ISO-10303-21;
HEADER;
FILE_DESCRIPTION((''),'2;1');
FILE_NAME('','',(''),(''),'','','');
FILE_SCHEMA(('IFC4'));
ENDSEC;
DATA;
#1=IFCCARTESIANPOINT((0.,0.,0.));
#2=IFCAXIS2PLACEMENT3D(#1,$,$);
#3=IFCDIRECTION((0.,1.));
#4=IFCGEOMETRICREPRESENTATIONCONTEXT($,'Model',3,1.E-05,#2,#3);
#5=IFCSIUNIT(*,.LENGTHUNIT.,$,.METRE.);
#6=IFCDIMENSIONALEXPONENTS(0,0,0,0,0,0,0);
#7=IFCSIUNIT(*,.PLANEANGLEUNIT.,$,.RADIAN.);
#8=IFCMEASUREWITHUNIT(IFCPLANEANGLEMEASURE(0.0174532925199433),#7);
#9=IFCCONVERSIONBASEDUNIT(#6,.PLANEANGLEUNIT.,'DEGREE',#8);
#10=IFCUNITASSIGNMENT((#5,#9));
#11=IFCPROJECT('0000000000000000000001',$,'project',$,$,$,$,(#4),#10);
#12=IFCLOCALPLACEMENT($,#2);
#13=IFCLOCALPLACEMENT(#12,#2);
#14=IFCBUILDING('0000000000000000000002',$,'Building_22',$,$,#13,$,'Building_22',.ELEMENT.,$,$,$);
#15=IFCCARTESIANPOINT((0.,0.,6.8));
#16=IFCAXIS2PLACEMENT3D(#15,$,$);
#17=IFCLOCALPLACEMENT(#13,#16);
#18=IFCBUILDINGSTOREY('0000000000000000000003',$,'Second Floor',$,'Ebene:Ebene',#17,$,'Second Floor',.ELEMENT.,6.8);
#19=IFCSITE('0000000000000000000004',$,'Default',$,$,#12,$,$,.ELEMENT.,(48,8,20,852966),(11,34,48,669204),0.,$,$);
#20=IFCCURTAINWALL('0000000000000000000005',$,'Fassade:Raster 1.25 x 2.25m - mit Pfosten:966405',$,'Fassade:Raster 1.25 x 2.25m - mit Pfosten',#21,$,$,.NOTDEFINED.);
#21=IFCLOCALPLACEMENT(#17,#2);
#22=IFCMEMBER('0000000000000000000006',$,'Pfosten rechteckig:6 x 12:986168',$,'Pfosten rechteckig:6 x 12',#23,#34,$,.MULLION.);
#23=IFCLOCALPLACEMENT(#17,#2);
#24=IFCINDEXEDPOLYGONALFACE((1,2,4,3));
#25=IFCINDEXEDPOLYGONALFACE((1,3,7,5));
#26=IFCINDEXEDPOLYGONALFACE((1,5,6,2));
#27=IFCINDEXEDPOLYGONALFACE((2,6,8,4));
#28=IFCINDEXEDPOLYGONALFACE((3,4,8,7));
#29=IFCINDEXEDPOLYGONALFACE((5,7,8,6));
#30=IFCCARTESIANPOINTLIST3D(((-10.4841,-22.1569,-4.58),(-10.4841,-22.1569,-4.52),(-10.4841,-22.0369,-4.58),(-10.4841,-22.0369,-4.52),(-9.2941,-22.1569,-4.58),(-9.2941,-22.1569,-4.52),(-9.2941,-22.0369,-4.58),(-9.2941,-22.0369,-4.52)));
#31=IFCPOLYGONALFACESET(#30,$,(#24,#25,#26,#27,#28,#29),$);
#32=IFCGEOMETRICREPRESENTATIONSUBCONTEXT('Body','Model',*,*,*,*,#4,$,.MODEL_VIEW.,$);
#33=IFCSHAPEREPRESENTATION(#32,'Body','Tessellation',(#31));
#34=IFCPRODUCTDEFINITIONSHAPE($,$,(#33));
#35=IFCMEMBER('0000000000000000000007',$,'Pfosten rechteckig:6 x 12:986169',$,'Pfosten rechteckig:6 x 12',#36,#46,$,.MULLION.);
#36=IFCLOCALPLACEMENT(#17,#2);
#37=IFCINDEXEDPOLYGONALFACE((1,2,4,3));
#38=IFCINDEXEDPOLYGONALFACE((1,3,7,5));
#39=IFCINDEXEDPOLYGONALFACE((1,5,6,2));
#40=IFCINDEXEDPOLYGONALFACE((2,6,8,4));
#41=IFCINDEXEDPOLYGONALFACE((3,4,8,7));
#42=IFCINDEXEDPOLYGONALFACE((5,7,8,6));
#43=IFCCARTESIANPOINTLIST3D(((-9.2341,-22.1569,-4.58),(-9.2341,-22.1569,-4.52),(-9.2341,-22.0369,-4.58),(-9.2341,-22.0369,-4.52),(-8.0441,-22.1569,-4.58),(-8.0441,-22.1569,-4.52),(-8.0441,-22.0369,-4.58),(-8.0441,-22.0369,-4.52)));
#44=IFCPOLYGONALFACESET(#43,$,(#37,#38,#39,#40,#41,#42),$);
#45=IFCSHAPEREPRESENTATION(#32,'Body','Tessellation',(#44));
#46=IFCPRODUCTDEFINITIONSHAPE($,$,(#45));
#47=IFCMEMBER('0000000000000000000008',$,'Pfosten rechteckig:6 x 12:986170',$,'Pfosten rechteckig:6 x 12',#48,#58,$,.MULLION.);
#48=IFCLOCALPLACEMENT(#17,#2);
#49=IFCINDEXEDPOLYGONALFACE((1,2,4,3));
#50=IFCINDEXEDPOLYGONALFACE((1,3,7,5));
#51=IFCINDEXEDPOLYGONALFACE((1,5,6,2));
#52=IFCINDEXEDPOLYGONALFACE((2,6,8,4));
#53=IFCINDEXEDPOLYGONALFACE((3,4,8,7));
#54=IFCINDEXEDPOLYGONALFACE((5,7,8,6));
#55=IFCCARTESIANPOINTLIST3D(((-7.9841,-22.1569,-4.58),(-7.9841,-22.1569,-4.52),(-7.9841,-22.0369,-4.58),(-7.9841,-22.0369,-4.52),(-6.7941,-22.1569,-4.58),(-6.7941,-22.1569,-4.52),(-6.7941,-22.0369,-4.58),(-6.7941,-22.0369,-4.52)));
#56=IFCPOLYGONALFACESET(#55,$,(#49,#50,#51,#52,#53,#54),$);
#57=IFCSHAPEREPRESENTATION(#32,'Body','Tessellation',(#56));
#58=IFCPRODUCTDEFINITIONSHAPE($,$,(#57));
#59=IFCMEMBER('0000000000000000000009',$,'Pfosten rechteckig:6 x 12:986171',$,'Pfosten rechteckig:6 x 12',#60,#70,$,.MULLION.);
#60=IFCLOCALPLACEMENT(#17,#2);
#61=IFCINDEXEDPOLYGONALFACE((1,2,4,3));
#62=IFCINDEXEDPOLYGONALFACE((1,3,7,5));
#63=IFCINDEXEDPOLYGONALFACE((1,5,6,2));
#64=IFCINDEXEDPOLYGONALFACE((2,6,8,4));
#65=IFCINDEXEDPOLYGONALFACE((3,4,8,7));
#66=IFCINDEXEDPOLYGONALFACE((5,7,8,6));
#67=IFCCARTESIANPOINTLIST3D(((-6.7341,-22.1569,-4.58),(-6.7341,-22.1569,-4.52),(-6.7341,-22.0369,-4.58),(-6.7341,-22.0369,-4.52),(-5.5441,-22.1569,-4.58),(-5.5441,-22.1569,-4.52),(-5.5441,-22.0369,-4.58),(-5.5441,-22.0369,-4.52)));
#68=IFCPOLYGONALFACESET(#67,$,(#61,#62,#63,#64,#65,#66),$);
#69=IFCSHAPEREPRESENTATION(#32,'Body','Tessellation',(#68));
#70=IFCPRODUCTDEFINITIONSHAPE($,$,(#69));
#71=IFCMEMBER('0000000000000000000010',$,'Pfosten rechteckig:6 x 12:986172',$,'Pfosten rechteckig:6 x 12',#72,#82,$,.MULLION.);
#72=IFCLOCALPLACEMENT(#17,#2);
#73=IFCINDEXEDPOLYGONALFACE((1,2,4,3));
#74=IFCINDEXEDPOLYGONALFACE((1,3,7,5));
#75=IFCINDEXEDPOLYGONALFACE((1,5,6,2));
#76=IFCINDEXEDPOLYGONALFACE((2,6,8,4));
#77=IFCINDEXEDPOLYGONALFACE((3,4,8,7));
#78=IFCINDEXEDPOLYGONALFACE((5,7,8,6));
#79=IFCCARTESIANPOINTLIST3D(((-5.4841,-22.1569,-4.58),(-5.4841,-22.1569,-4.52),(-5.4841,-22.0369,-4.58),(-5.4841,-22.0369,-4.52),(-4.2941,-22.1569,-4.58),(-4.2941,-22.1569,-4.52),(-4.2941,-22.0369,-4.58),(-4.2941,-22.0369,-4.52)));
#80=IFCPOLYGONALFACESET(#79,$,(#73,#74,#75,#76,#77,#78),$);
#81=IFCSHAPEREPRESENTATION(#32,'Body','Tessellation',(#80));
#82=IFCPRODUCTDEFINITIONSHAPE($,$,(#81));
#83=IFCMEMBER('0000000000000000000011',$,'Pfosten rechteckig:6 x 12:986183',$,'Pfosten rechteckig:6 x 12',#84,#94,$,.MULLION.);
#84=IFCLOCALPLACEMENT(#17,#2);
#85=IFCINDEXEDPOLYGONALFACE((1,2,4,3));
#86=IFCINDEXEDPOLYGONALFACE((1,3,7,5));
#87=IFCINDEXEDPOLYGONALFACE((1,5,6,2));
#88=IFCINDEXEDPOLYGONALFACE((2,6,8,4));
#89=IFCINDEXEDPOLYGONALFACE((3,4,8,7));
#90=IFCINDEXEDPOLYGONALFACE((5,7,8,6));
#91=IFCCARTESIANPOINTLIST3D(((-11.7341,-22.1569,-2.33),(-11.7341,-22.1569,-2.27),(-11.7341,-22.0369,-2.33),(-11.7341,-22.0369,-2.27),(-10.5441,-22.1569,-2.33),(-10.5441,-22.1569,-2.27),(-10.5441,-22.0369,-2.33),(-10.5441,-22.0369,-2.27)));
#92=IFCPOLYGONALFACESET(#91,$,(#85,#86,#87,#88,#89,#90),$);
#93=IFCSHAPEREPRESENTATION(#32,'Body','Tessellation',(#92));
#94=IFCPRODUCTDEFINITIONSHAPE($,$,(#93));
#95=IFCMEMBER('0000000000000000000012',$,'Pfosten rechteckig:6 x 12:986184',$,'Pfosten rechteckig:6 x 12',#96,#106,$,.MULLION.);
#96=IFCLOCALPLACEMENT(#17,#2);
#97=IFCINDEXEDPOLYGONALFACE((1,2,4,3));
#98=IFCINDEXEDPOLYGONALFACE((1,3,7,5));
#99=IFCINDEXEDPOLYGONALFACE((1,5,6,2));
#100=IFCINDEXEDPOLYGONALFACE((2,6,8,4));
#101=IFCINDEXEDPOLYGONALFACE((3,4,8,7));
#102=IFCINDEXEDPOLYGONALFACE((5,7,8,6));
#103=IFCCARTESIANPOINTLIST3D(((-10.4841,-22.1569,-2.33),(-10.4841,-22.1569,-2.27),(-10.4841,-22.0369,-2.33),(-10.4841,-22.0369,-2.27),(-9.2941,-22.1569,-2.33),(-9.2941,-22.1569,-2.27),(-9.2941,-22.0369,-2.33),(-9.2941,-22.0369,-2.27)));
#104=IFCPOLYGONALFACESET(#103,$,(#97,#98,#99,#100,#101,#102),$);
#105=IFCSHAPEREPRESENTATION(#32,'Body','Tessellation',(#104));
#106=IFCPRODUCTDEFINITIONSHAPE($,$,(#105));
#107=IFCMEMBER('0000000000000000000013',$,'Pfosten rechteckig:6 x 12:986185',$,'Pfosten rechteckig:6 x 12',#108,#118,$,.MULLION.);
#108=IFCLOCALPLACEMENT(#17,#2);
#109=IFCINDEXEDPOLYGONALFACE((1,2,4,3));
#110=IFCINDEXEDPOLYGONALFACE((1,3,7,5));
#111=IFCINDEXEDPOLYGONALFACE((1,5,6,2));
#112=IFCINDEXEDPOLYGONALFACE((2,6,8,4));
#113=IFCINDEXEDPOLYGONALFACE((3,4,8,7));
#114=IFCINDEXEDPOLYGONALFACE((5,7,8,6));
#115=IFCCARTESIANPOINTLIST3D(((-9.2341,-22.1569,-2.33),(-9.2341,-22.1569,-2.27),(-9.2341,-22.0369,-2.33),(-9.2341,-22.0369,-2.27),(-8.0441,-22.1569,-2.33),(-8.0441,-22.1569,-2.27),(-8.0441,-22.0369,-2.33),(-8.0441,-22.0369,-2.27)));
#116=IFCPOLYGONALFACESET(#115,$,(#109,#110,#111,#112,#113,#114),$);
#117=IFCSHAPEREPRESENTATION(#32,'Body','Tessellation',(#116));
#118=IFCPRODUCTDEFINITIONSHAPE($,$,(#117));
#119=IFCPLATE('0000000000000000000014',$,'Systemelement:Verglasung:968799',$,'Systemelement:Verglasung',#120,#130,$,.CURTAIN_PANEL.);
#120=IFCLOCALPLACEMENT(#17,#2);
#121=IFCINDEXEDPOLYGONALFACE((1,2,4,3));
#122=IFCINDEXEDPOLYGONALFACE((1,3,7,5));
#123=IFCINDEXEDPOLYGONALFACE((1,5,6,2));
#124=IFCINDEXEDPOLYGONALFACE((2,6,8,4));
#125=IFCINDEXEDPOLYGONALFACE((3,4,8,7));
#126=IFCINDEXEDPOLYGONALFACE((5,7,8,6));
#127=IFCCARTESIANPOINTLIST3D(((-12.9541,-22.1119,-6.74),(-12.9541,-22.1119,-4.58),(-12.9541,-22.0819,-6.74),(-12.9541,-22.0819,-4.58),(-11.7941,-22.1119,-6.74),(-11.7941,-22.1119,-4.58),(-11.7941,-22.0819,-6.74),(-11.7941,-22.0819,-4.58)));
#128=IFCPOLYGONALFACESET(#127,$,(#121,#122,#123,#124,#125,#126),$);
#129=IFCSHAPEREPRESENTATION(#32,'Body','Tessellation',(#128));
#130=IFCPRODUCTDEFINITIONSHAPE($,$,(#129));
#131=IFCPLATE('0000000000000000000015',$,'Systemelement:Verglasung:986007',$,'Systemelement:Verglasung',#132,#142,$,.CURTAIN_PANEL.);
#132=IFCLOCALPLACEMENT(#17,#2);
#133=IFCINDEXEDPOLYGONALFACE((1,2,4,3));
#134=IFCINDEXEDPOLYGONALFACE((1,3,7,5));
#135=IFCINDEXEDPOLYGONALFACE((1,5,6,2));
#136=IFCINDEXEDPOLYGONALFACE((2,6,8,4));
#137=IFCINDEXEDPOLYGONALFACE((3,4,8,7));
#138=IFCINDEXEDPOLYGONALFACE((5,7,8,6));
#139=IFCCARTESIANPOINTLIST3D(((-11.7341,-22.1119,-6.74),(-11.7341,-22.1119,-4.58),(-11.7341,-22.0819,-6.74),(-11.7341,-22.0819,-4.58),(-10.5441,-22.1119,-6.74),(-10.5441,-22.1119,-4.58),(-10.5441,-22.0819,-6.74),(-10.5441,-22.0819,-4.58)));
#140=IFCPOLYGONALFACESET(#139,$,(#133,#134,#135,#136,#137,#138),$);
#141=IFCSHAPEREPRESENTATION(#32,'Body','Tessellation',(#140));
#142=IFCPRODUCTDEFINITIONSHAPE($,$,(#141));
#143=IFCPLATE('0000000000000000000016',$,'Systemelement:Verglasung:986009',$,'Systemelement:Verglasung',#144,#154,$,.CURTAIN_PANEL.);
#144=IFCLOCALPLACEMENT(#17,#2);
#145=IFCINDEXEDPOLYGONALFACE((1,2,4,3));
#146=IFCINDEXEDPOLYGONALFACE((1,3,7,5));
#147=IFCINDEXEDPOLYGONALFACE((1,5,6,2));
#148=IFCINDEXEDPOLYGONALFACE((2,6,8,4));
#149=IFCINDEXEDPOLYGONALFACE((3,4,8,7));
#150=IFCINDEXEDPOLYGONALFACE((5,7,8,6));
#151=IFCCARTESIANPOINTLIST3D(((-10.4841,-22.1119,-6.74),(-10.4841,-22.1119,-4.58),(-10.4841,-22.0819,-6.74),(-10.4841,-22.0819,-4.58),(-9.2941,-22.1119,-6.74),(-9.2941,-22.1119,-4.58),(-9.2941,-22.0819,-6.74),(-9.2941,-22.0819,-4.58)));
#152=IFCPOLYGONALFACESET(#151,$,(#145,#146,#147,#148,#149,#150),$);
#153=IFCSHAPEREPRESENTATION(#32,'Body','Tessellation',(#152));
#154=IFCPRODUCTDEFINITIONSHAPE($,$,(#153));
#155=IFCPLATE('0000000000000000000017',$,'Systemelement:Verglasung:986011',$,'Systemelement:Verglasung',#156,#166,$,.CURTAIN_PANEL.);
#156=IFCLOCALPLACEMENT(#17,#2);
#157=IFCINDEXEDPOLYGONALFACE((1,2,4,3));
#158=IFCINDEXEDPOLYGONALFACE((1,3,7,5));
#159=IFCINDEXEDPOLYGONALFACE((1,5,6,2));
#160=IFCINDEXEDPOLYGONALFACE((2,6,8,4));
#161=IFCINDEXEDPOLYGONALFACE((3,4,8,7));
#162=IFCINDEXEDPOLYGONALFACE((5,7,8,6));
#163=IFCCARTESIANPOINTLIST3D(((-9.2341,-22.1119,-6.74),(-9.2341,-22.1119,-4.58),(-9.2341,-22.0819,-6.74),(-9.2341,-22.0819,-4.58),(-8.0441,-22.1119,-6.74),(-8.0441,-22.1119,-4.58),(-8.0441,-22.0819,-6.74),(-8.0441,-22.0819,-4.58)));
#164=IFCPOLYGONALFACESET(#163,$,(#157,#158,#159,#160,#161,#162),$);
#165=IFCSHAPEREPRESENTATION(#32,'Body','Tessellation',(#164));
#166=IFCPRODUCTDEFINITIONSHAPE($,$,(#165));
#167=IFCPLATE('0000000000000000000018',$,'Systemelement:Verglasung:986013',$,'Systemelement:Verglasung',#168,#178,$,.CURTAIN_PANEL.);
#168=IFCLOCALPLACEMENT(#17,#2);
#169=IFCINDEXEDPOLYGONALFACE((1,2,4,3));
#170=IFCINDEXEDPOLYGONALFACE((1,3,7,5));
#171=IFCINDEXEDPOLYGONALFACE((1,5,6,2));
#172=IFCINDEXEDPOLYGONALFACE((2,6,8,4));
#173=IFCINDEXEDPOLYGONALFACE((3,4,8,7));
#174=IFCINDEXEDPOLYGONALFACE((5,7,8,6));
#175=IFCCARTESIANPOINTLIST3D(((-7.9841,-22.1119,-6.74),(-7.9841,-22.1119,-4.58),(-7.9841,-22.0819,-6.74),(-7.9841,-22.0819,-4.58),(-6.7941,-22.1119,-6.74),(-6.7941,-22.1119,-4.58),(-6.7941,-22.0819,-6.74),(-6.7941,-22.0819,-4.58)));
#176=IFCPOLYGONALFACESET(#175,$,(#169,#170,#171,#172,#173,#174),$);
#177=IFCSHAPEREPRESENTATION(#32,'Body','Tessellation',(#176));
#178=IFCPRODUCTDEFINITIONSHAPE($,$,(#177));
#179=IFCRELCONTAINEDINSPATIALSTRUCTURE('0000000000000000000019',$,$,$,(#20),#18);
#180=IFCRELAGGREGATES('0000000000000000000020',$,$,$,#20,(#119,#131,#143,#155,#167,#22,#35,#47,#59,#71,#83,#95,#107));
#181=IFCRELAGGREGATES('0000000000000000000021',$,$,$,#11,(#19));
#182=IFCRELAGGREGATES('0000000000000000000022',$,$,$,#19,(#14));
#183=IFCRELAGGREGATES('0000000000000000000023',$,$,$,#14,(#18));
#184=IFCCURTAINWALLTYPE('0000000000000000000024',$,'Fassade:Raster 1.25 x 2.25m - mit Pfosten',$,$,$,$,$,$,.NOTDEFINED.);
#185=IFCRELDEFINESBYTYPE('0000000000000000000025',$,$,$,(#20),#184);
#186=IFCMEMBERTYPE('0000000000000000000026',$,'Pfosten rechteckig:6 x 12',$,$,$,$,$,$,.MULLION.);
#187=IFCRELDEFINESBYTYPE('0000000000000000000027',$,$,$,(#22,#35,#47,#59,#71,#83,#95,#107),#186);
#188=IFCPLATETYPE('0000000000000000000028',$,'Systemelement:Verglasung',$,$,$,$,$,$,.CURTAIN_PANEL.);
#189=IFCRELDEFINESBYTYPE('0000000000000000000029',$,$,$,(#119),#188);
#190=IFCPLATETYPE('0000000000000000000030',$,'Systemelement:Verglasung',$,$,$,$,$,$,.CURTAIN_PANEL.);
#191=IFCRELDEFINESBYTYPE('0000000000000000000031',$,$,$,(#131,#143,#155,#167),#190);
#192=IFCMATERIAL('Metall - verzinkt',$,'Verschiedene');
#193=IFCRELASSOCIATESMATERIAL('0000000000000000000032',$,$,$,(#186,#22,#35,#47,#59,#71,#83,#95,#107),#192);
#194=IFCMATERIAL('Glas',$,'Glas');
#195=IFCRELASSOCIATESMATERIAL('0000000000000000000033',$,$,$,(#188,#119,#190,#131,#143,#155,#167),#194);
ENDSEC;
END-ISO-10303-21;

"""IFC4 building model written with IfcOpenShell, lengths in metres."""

from ifc_helpers import new_model, entity, si_unit, converted_unit, direction, frame, origin, place, context, subcontext, project, spatial, indexed_curve, outline, extrude, source, transform, mapped, material, type_object, type_shapes, element, aggregate, save


model = new_model("IFC4")

# Units and contexts
model_context = context("Model", 3, precision=1e-05, world=origin(), true_north=direction((0.0, 1.0)))
body_context = subcontext(model_context, "Body", "Model", "MODEL_VIEW")
ifc_project = project(units=[si_unit("LENGTHUNIT", "METRE"), converted_unit("PLANEANGLEUNIT", "DEGREE", entity("IfcPlaneAngleMeasure", 0.0174532925199433), si_unit("PLANEANGLEUNIT", "RADIAN"), dimensions=[0, 0, 0, 0, 0, 0, 0])], contexts=[model_context])

# Site, building, storey
site_placement = place(None, origin())
site = spatial("IfcSite", under=ifc_project, at=site_placement, Name="Default", CompositionType="ELEMENT", RefLatitude=(48, 8, 20, 852966), RefLongitude=(11, 34, 48, 669204), RefElevation=0.0)
building_placement = place(site_placement, origin())
building = spatial("IfcBuilding", under=site, at=building_placement, Name="Building_22", LongName="Building_22", CompositionType="ELEMENT")
storey_placement = place(building_placement, frame((0.0, 0.0, 6.8)))
storey = spatial("IfcBuildingStorey", under=building, at=storey_placement, Name="Second Floor", ObjectType="Ebene:Ebene", LongName="Second Floor", CompositionType="ELEMENT", Elevation=6.8)

# Curtain wall, members, plates
curtain_wall_type = type_object("IfcCurtainWallType", Name="Fassade:Raster 1.25 x 2.25m - mit Pfosten", PredefinedType="NOTDEFINED")
curtain_wall_placement = place(storey_placement, frame((0.0, 0.0, -6.8)))
curtain_wall = element("IfcCurtainWall", 1, at=curtain_wall_placement, inside=storey, type_object=curtain_wall_type, Name="Fassade:Raster 1.25 x 2.25m - mit Pfosten:966405", ObjectType="Fassade:Raster 1.25 x 2.25m - mit Pfosten", PredefinedType="NOTDEFINED")
ifc_material_1 = material(Name="Metall - verzinkt", Category="Verschiedene")
member_type_1 = type_object("IfcMemberType", Name="Pfosten rechteckig:6 x 12", PredefinedType="MULLION", material=ifc_material_1)
shared_shape_1 = source(origin(), body_context, "Body", "SweptSolid", [
    extrude(outline(indexed_curve([(-0.03, -0.06), (0.03, -0.06), (0.03, 0.06), (-0.03, 0.06), (-0.03, -0.06)], self_intersect=False)), frame((0.0, 0.0, -1.19), z_axis=(0.0, 0.0, 1.0), x_axis=(-1.0, 0.0, 0.0)), (0.0, 0.0, 1.0), 1.19),
])
type_shapes(member_type_1, [shared_shape_1])
member_1_placement = place(curtain_wall_placement, frame((-9.2941, -22.0969, 2.25), z_axis=(1.0, 0.0, 0.0), x_axis=(0.0, 0.0, 1.0)))
member_1 = element("IfcMember", 2, at=member_1_placement, type_object=member_type_1, material=ifc_material_1, Name="Pfosten rechteckig:6 x 12:986168", ObjectType="Pfosten rechteckig:6 x 12", PredefinedType="MULLION", context=body_context, shape_type="MappedRepresentation", body=[
    mapped(shared_shape_1, transform((0.0, 0.0, 0.0), scale=1.0)),
])
member_2_placement = place(curtain_wall_placement, frame((-8.0441, -22.0969, 2.25), z_axis=(1.0, 0.0, 0.0), x_axis=(0.0, 0.0, 1.0)))
member_2 = element("IfcMember", 3, at=member_2_placement, type_object=member_type_1, material=ifc_material_1, Name="Pfosten rechteckig:6 x 12:986169", ObjectType="Pfosten rechteckig:6 x 12", PredefinedType="MULLION", context=body_context, shape_type="MappedRepresentation", body=[
    mapped(shared_shape_1, transform((0.0, 0.0, 0.0), scale=1.0)),
])
member_3_placement = place(curtain_wall_placement, frame((-6.7941, -22.0969, 2.25), z_axis=(1.0, 0.0, 0.0), x_axis=(0.0, 0.0, 1.0)))
member_3 = element("IfcMember", 4, at=member_3_placement, type_object=member_type_1, material=ifc_material_1, Name="Pfosten rechteckig:6 x 12:986170", ObjectType="Pfosten rechteckig:6 x 12", PredefinedType="MULLION", context=body_context, shape_type="MappedRepresentation", body=[
    mapped(shared_shape_1, transform((0.0, 0.0, 0.0), scale=1.0)),
])
member_4_placement = place(curtain_wall_placement, frame((-5.5441, -22.0969, 2.25), z_axis=(1.0, 0.0, 0.0), x_axis=(0.0, 0.0, 1.0)))
member_4 = element("IfcMember", 5, at=member_4_placement, type_object=member_type_1, material=ifc_material_1, Name="Pfosten rechteckig:6 x 12:986171", ObjectType="Pfosten rechteckig:6 x 12", PredefinedType="MULLION", context=body_context, shape_type="MappedRepresentation", body=[
    mapped(shared_shape_1, transform((0.0, 0.0, 0.0), scale=1.0)),
])
member_5_placement = place(curtain_wall_placement, frame((-4.2941, -22.0969, 2.25), z_axis=(1.0, 0.0, 0.0), x_axis=(0.0, 0.0, 1.0)))
member_5 = element("IfcMember", 6, at=member_5_placement, type_object=member_type_1, material=ifc_material_1, Name="Pfosten rechteckig:6 x 12:986172", ObjectType="Pfosten rechteckig:6 x 12", PredefinedType="MULLION", context=body_context, shape_type="MappedRepresentation", body=[
    mapped(shared_shape_1, transform((0.0, 0.0, 0.0), scale=1.0)),
])
member_6_placement = place(curtain_wall_placement, frame((-10.5441, -22.0969, 4.5), z_axis=(1.0, 0.0, 0.0), x_axis=(0.0, 0.0, 1.0)))
member_6 = element("IfcMember", 7, at=member_6_placement, type_object=member_type_1, material=ifc_material_1, Name="Pfosten rechteckig:6 x 12:986183", ObjectType="Pfosten rechteckig:6 x 12", PredefinedType="MULLION", context=body_context, shape_type="MappedRepresentation", body=[
    mapped(shared_shape_1, transform((0.0, 0.0, 0.0), scale=1.0)),
])
member_7_placement = place(curtain_wall_placement, frame((-9.2941, -22.0969, 4.5), z_axis=(1.0, 0.0, 0.0), x_axis=(0.0, 0.0, 1.0)))
member_7 = element("IfcMember", 8, at=member_7_placement, type_object=member_type_1, material=ifc_material_1, Name="Pfosten rechteckig:6 x 12:986184", ObjectType="Pfosten rechteckig:6 x 12", PredefinedType="MULLION", context=body_context, shape_type="MappedRepresentation", body=[
    mapped(shared_shape_1, transform((0.0, 0.0, 0.0), scale=1.0)),
])
member_8_placement = place(curtain_wall_placement, frame((-8.0441, -22.0969, 4.5), z_axis=(1.0, 0.0, 0.0), x_axis=(0.0, 0.0, 1.0)))
member_8 = element("IfcMember", 9, at=member_8_placement, type_object=member_type_1, material=ifc_material_1, Name="Pfosten rechteckig:6 x 12:986185", ObjectType="Pfosten rechteckig:6 x 12", PredefinedType="MULLION", context=body_context, shape_type="MappedRepresentation", body=[
    mapped(shared_shape_1, transform((0.0, 0.0, 0.0), scale=1.0)),
])
ifc_material_2 = material(Name="Glas", Category="Glas")
plate_type_1 = type_object("IfcPlateType", Name="Systemelement:Verglasung", PredefinedType="CURTAIN_PANEL", material=ifc_material_2)
shared_shape_2 = source(origin(), body_context, "Body", "SweptSolid", [
    extrude(outline(indexed_curve([(-0.015, -0.58), (0.015, -0.58), (0.015, 0.58), (-0.015, 0.58), (-0.015, -0.58)], self_intersect=False)), frame((0.0, 0.0, 0.0), z_axis=(0.0, 0.0, 1.0), x_axis=(0.0, 1.0, 0.0)), (0.0, 0.0, 1.0), 2.16),
])
type_shapes(plate_type_1, [shared_shape_2])
plate_1_placement = place(curtain_wall_placement, frame((-12.3741, -22.0969, 0.06)))
plate_1 = element("IfcPlate", 10, at=plate_1_placement, type_object=plate_type_1, material=ifc_material_2, Name="Systemelement:Verglasung:968799", ObjectType="Systemelement:Verglasung", PredefinedType="CURTAIN_PANEL", context=body_context, shape_type="MappedRepresentation", body=[
    mapped(shared_shape_2, transform((0.0, 0.0, 0.0), scale=1.0)),
])
plate_type_2 = type_object("IfcPlateType", Name="Systemelement:Verglasung", PredefinedType="CURTAIN_PANEL", material=ifc_material_2)
shared_shape_3 = source(origin(), body_context, "Body", "SweptSolid", [
    extrude(outline(indexed_curve([(-0.015, -0.595), (0.015, -0.595), (0.015, 0.595), (-0.015, 0.595), (-0.015, -0.595)], self_intersect=False)), frame((0.0, 0.0, 0.0), z_axis=(0.0, 0.0, 1.0), x_axis=(0.0, 1.0, 0.0)), (0.0, 0.0, 1.0), 2.16),
])
type_shapes(plate_type_2, [shared_shape_3])
plate_2_placement = place(curtain_wall_placement, frame((-11.1391, -22.0969, 0.06)))
plate_2 = element("IfcPlate", 11, at=plate_2_placement, type_object=plate_type_2, material=ifc_material_2, Name="Systemelement:Verglasung:986007", ObjectType="Systemelement:Verglasung", PredefinedType="CURTAIN_PANEL", context=body_context, shape_type="MappedRepresentation", body=[
    mapped(shared_shape_3, transform((0.0, 0.0, 0.0), scale=1.0)),
])
plate_3_placement = place(curtain_wall_placement, frame((-9.8891, -22.0969, 0.06)))
plate_3 = element("IfcPlate", 12, at=plate_3_placement, type_object=plate_type_2, material=ifc_material_2, Name="Systemelement:Verglasung:986009", ObjectType="Systemelement:Verglasung", PredefinedType="CURTAIN_PANEL", context=body_context, shape_type="MappedRepresentation", body=[
    mapped(shared_shape_3, transform((0.0, 0.0, 0.0), scale=1.0)),
])
plate_4_placement = place(curtain_wall_placement, frame((-8.6391, -22.0969, 0.06)))
plate_4 = element("IfcPlate", 13, at=plate_4_placement, type_object=plate_type_2, material=ifc_material_2, Name="Systemelement:Verglasung:986011", ObjectType="Systemelement:Verglasung", PredefinedType="CURTAIN_PANEL", context=body_context, shape_type="MappedRepresentation", body=[
    mapped(shared_shape_3, transform((0.0, 0.0, 0.0), scale=1.0)),
])
plate_5_placement = place(curtain_wall_placement, frame((-7.3891, -22.0969, 0.06)))
plate_5 = element("IfcPlate", 14, at=plate_5_placement, type_object=plate_type_2, material=ifc_material_2, Name="Systemelement:Verglasung:986013", ObjectType="Systemelement:Verglasung", PredefinedType="CURTAIN_PANEL", context=body_context, shape_type="MappedRepresentation", body=[
    mapped(shared_shape_3, transform((0.0, 0.0, 0.0), scale=1.0)),
])
aggregate(curtain_wall, [plate_1, plate_2, plate_3, plate_4, plate_5, member_1, member_2, member_3, member_4, member_5, member_6, member_7, member_8])

save(model, "model.ifc")
